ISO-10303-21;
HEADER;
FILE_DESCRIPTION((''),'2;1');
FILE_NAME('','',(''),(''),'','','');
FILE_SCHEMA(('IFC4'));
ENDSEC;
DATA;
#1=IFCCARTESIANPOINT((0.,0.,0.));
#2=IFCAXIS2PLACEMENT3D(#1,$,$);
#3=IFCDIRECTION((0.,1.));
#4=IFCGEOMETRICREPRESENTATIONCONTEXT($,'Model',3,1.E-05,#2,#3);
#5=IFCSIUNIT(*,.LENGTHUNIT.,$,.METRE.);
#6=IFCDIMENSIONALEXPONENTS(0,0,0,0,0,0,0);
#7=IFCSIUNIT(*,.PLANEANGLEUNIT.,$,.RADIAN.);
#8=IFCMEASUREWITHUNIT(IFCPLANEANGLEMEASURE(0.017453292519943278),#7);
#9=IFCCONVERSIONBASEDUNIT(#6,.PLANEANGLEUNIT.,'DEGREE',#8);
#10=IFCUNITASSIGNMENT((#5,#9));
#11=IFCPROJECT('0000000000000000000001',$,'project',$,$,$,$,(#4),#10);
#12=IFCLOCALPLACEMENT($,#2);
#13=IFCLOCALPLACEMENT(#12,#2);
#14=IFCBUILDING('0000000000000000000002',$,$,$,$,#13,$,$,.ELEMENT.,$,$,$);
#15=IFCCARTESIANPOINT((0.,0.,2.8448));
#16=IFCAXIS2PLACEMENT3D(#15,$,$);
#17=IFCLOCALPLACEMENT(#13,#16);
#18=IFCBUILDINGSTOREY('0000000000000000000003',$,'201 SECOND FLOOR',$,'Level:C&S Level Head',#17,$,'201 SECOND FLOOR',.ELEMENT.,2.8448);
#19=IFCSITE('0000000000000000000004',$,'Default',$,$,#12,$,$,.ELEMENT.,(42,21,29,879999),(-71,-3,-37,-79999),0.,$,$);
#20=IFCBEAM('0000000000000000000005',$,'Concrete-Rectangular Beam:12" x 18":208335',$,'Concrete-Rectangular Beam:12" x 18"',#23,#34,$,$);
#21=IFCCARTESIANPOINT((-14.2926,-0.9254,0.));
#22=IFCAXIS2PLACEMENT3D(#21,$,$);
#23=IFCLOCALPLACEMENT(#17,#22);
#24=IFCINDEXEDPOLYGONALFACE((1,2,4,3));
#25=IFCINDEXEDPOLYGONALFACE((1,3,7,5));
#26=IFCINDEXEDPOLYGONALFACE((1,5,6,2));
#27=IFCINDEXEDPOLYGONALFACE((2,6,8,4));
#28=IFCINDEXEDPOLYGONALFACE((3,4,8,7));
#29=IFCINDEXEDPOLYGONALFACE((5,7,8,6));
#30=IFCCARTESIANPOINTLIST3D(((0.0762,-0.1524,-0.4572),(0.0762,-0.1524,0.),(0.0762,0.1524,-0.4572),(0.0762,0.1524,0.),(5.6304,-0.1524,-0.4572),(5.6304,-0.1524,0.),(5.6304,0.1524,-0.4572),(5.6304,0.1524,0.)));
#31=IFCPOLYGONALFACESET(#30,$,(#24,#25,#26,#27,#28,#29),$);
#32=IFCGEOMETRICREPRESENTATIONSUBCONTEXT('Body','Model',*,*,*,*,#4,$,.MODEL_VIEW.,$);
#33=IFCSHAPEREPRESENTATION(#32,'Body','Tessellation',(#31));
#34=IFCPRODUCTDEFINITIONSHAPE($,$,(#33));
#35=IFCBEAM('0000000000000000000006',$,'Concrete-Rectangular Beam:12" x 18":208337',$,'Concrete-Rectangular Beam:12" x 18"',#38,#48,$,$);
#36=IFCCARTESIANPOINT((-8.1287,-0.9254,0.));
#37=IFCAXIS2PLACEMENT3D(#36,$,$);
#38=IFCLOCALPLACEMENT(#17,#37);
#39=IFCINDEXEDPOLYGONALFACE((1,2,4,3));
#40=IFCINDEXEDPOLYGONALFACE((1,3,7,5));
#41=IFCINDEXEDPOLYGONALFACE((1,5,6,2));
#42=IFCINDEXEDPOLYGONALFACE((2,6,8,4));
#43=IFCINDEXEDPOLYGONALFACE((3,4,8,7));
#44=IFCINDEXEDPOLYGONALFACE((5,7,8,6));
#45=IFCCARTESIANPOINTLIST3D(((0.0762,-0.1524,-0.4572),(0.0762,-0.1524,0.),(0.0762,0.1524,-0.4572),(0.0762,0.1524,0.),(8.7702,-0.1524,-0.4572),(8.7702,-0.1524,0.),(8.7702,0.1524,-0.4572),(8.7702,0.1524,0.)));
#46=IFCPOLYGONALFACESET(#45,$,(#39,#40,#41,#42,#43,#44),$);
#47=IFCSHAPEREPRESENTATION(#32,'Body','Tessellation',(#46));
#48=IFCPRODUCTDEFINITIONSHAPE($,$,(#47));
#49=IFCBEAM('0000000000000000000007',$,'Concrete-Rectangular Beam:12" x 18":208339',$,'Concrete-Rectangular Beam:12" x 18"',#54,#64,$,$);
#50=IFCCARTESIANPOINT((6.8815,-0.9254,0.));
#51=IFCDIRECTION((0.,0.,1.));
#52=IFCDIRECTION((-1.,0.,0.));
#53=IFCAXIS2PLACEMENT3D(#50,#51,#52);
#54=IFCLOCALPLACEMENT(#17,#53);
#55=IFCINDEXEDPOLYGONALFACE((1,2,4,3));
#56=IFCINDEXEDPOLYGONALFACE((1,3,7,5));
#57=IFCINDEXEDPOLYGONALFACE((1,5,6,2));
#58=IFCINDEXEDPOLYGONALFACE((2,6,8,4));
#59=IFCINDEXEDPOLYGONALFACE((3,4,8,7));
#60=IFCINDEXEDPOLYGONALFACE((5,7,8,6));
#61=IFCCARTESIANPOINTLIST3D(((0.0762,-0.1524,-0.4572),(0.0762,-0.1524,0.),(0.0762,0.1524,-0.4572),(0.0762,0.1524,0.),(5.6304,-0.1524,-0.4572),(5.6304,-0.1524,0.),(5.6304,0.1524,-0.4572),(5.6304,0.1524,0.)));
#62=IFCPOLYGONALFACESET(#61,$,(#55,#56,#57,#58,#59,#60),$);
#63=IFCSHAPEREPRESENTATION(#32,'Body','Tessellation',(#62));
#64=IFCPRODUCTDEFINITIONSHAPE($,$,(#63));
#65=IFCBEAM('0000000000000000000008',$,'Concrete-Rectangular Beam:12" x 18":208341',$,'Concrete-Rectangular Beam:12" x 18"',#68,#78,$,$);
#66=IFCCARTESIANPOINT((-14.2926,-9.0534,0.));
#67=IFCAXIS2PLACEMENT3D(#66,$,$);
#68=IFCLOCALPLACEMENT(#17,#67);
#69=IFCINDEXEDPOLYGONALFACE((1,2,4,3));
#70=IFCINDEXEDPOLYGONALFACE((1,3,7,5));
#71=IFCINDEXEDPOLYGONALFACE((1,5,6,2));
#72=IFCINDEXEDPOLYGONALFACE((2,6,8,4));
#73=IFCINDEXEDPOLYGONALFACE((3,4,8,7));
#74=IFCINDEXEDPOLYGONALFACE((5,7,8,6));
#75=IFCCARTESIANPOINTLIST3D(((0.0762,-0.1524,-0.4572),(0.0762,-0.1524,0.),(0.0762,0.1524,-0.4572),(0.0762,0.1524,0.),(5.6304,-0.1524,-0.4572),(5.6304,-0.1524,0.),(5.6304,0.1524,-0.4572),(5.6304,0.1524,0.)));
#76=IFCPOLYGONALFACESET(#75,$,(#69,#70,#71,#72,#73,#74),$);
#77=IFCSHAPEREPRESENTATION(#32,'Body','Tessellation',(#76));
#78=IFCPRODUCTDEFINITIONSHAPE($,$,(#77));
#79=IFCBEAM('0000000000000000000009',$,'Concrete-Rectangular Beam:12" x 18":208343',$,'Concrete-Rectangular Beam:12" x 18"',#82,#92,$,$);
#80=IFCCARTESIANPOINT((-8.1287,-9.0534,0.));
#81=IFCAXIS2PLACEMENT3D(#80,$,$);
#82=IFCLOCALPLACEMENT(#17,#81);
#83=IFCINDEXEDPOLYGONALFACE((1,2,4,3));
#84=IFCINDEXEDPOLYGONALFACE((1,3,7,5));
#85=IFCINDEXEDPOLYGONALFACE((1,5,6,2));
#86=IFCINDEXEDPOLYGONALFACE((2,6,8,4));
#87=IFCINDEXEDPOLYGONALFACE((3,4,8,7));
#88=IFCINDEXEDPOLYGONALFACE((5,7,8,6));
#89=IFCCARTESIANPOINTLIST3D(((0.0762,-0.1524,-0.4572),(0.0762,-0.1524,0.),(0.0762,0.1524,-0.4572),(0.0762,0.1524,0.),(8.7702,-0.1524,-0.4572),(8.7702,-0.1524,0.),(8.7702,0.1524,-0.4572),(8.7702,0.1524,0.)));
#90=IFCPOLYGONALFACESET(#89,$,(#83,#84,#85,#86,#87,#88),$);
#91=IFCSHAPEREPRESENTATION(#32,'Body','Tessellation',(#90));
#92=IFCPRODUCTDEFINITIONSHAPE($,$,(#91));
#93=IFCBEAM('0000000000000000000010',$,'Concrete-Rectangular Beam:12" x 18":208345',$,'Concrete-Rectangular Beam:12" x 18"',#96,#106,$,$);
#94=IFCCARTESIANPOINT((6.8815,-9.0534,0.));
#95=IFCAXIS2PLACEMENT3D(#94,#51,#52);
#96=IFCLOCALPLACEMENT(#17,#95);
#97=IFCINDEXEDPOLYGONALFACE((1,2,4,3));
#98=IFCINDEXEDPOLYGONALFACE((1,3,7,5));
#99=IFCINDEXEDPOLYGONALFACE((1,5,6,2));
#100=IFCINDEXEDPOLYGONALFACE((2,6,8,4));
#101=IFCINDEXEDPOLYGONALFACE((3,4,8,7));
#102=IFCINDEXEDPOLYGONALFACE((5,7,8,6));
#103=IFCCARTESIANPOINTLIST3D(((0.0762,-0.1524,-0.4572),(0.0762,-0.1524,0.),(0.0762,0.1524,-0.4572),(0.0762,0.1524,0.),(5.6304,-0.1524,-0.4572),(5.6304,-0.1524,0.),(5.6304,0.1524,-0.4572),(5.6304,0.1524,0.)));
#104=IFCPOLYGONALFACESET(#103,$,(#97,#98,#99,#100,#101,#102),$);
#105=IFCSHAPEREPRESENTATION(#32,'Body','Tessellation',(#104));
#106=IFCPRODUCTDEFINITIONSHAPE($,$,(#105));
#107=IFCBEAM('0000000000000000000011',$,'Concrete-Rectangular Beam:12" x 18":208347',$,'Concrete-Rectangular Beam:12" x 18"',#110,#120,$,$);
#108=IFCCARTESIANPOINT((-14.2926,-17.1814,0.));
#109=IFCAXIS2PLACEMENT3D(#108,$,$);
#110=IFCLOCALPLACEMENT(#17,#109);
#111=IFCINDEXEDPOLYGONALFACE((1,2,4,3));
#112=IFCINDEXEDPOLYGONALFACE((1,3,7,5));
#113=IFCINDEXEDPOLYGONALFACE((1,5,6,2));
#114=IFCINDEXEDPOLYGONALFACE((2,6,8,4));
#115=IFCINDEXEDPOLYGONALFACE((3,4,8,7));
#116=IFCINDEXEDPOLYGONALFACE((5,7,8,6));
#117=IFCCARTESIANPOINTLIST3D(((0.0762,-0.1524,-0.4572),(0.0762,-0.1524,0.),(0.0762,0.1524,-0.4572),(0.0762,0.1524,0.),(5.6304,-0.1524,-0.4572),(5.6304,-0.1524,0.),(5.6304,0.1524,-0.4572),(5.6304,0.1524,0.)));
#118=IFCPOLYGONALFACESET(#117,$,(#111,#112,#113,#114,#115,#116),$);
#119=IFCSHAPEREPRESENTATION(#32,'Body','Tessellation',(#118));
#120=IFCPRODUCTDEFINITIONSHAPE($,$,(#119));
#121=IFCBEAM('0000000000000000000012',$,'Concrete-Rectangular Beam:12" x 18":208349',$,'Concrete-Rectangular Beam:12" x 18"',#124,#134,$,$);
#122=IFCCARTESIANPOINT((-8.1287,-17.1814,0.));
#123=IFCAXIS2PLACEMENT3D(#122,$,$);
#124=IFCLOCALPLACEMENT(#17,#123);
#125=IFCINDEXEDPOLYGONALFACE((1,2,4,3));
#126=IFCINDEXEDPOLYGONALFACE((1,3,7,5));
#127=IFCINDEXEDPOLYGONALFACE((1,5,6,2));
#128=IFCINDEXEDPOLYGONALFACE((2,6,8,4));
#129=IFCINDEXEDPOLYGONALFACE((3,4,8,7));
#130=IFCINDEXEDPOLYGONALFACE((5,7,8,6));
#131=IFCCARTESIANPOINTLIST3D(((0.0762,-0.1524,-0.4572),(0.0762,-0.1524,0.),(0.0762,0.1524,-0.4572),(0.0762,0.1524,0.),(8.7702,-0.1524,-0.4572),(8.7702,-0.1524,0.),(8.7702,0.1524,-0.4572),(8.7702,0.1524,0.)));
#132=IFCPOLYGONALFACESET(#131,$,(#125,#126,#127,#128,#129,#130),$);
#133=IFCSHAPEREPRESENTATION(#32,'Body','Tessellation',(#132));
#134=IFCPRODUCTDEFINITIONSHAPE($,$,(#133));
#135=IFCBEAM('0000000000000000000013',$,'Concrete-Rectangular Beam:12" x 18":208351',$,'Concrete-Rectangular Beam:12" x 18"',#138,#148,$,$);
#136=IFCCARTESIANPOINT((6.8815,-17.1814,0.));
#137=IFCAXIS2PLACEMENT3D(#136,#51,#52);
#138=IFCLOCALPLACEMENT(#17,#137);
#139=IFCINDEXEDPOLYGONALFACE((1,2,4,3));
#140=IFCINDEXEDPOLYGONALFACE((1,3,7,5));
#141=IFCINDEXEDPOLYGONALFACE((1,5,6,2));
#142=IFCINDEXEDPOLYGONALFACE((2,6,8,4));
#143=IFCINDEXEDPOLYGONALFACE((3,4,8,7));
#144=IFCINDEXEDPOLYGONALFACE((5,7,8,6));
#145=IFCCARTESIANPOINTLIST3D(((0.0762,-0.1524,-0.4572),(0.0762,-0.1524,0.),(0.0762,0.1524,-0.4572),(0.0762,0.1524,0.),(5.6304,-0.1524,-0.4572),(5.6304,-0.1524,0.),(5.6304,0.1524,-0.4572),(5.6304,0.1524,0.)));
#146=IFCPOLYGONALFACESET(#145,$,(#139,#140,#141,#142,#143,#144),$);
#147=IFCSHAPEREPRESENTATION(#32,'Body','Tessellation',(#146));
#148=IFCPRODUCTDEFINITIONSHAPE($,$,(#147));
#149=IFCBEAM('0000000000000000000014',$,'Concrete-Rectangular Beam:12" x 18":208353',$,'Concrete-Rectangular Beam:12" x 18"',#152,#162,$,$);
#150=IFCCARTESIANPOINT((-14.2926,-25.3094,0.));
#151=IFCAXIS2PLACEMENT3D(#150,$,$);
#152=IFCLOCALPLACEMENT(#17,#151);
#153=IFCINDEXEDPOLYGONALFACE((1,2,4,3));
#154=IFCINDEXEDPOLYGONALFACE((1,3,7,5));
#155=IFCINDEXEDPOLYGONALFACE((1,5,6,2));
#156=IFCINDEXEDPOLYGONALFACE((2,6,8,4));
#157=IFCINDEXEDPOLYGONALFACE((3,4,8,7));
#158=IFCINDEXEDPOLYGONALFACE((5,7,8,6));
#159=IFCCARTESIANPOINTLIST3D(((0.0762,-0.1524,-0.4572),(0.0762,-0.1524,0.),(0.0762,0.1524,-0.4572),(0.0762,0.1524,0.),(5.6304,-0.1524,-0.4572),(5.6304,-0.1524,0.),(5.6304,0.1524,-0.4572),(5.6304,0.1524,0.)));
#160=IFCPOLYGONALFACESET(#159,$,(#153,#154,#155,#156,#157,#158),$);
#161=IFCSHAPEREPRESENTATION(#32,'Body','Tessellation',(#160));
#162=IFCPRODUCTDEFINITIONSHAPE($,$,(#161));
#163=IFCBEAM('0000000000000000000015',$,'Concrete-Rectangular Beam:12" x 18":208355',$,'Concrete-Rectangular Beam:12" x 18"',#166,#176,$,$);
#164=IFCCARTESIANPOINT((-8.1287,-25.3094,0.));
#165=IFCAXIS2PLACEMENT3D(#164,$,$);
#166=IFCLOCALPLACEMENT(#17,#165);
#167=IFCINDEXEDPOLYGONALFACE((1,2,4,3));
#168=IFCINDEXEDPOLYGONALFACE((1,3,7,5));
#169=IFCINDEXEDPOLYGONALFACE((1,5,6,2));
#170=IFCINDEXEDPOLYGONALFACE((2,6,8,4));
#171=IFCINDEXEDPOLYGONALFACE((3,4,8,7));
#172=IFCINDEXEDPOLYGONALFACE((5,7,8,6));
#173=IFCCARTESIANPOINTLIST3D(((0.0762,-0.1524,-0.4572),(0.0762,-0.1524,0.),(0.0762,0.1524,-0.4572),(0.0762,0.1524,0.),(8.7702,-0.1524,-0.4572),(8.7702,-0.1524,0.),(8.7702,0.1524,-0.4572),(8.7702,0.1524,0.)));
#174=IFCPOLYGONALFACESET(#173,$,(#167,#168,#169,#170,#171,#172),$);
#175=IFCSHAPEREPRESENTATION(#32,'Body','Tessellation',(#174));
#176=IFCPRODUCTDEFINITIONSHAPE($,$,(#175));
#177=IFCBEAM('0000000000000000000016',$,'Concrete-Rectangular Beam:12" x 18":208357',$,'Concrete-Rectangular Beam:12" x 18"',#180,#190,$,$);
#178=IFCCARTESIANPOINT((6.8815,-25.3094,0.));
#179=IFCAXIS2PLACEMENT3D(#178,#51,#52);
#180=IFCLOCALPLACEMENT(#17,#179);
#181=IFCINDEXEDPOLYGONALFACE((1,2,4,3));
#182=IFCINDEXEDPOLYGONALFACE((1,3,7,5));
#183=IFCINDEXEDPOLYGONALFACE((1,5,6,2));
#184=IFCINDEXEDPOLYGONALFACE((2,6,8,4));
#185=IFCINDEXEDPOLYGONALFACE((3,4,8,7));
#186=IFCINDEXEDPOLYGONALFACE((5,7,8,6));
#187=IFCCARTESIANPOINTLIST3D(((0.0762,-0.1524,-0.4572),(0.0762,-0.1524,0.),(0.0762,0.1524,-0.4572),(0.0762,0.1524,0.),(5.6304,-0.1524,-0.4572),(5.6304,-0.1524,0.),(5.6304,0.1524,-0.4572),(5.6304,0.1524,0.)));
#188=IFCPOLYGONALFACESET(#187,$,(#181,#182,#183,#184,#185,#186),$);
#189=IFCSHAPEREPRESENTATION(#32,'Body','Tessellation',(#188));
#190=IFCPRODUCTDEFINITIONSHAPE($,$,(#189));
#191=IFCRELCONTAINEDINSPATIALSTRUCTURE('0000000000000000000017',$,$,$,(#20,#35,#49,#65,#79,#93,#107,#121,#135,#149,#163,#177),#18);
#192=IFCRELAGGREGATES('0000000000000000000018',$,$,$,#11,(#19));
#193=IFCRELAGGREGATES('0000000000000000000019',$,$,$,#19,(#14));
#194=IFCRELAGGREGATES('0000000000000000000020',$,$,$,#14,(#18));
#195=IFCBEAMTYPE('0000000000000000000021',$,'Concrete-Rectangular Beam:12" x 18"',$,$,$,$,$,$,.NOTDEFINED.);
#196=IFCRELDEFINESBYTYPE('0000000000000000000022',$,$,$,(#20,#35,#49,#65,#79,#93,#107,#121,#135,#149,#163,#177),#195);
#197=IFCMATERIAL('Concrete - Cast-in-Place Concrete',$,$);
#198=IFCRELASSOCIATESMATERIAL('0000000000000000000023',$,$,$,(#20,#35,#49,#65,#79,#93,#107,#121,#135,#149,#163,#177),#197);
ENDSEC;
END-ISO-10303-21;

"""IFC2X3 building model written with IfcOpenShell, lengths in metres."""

from ifc_helpers import new_model, entity, si_unit, converted_unit, direction, frame, frame_2d, origin, origin_2d_with_axis, place, context, subcontext, project, spatial, rectangle, extrude, material, type_object, element, save


model = new_model("IFC2X3")

# Units and contexts
model_context = context("Model", 3, precision=1e-05, world=origin(), true_north=direction((0.0, 1.0)))
body_context = subcontext(model_context, "Body", "Model", "MODEL_VIEW")
ifc_project = project(units=[si_unit("LENGTHUNIT", "METRE"), converted_unit("PLANEANGLEUNIT", "DEGREE", entity("IfcPlaneAngleMeasure", 0.017453292519943278), si_unit("PLANEANGLEUNIT", "RADIAN"), dimensions=[0, 0, 0, 0, 0, 0, 0])], contexts=[model_context])

# Site, building, storey
site_placement = place(None, origin())
site = spatial("IfcSite", under=ifc_project, at=site_placement, Name="Default", CompositionType="ELEMENT", RefLatitude=(42, 21, 29, 879999), RefLongitude=(-71, -3, -37, -79999), RefElevation=0.0)
building_placement = place(site_placement, origin())
building = spatial("IfcBuilding", under=site, at=building_placement, CompositionType="ELEMENT")
storey_placement = place(building_placement, frame((0.0, 0.0, 2.8448)))
storey = spatial("IfcBuildingStorey", under=building, at=storey_placement, Name="201 SECOND FLOOR", ObjectType="Level:C&S Level Head", LongName="201 SECOND FLOOR", CompositionType="ELEMENT", Elevation=2.8448)

# Beams
ifc_material_1 = material(Name="Concrete - Cast-in-Place Concrete")
beam_type = type_object("IfcBeamType", Name="Concrete-Rectangular Beam:12\" x 18\"", PredefinedType="NOTDEFINED")
beam_1_placement = place(storey_placement, frame((-14.2926, -0.9254, 0.0)))
element("IfcBeam", 1, at=beam_1_placement, inside=storey, type_object=beam_type, material=ifc_material_1, Name="Concrete-Rectangular Beam:12\" x 18\":208335", ObjectType="Concrete-Rectangular Beam:12\" x 18\"", context=body_context, shape_type="SweptSolid", body=[
    extrude(rectangle(XDim=0.4572, YDim=0.3048, at=frame_2d((0.0, 0.0), x_axis=(1.0, 0.0))), frame((0.0762, 0.0, -0.2286), z_axis=(1.0, 0.0, 0.0), x_axis=(0.0, 0.0, -1.0)), (0.0, 0.0, 1.0), 5.5542),
])
beam_2_placement = place(storey_placement, frame((-8.1287, -0.9254, 0.0)))
element("IfcBeam", 2, at=beam_2_placement, inside=storey, type_object=beam_type, material=ifc_material_1, Name="Concrete-Rectangular Beam:12\" x 18\":208337", ObjectType="Concrete-Rectangular Beam:12\" x 18\"", context=body_context, shape_type="SweptSolid", body=[
    extrude(rectangle(XDim=0.4572, YDim=0.3048, at=frame_2d((0.0, 0.0), x_axis=(1.0, 0.0))), frame((0.0762, 0.0, -0.2286), z_axis=(1.0, 0.0, 0.0), x_axis=(0.0, 0.0, -1.0)), (0.0, 0.0, 1.0), 8.694),
])
beam_3_placement = place(storey_placement, frame((6.8815, -0.9254, 0.0), z_axis=(0.0, 0.0, 1.0), x_axis=(-1.0, 0.0, 0.0)))
element("IfcBeam", 3, at=beam_3_placement, inside=storey, type_object=beam_type, material=ifc_material_1, Name="Concrete-Rectangular Beam:12\" x 18\":208339", ObjectType="Concrete-Rectangular Beam:12\" x 18\"", context=body_context, shape_type="SweptSolid", body=[
    extrude(rectangle(XDim=0.4572, YDim=0.3048, at=frame_2d((0.0, 0.0), x_axis=(1.0, 0.0))), frame((0.0762, 0.0, -0.2286), z_axis=(1.0, 0.0, 0.0), x_axis=(0.0, 0.0, -1.0)), (0.0, 0.0, 1.0), 5.5542),
])
beam_4_placement = place(storey_placement, frame((-14.2926, -9.0534, 0.0)))
element("IfcBeam", 4, at=beam_4_placement, inside=storey, type_object=beam_type, material=ifc_material_1, Name="Concrete-Rectangular Beam:12\" x 18\":208341", ObjectType="Concrete-Rectangular Beam:12\" x 18\"", context=body_context, shape_type="SweptSolid", body=[
    extrude(rectangle(XDim=0.4572, YDim=0.3048, at=frame_2d((0.0, 0.0), x_axis=(1.0, 0.0))), frame((0.0762, 0.0, -0.2286), z_axis=(1.0, 0.0, 0.0), x_axis=(0.0, 0.0, -1.0)), (0.0, 0.0, 1.0), 5.5542),
])
beam_5_placement = place(storey_placement, frame((-8.1287, -9.0534, 0.0)))
element("IfcBeam", 5, at=beam_5_placement, inside=storey, type_object=beam_type, material=ifc_material_1, Name="Concrete-Rectangular Beam:12\" x 18\":208343", ObjectType="Concrete-Rectangular Beam:12\" x 18\"", context=body_context, shape_type="SweptSolid", body=[
    extrude(rectangle(XDim=0.4572, YDim=0.3048, at=frame_2d((0.0, 0.0), x_axis=(1.0, 0.0))), frame((0.0762, 0.0, -0.2286), z_axis=(1.0, 0.0, 0.0), x_axis=(0.0, 0.0, -1.0)), (0.0, 0.0, 1.0), 8.694),
])
beam_6_placement = place(storey_placement, frame((6.8815, -9.0534, 0.0), z_axis=(0.0, 0.0, 1.0), x_axis=(-1.0, 0.0, 0.0)))
element("IfcBeam", 6, at=beam_6_placement, inside=storey, type_object=beam_type, material=ifc_material_1, Name="Concrete-Rectangular Beam:12\" x 18\":208345", ObjectType="Concrete-Rectangular Beam:12\" x 18\"", context=body_context, shape_type="SweptSolid", body=[
    extrude(rectangle(XDim=0.4572, YDim=0.3048, at=frame_2d((0.0, 0.0), x_axis=(1.0, 0.0))), frame((0.0762, 0.0, -0.2286), z_axis=(1.0, 0.0, 0.0), x_axis=(0.0, 0.0, -1.0)), (0.0, 0.0, 1.0), 5.5542),
])
beam_7_placement = place(storey_placement, frame((-14.2926, -17.1814, 0.0)))
element("IfcBeam", 7, at=beam_7_placement, inside=storey, type_object=beam_type, material=ifc_material_1, Name="Concrete-Rectangular Beam:12\" x 18\":208347", ObjectType="Concrete-Rectangular Beam:12\" x 18\"", context=body_context, shape_type="SweptSolid", body=[
    extrude(rectangle(XDim=0.4572, YDim=0.3048, at=origin_2d_with_axis()), frame((0.0762, 0.0, -0.2286), z_axis=(1.0, 0.0, 0.0), x_axis=(0.0, 0.0, -1.0)), (0.0, 0.0, 1.0), 5.5542),
])
beam_8_placement = place(storey_placement, frame((-8.1287, -17.1814, 0.0)))
element("IfcBeam", 8, at=beam_8_placement, inside=storey, type_object=beam_type, material=ifc_material_1, Name="Concrete-Rectangular Beam:12\" x 18\":208349", ObjectType="Concrete-Rectangular Beam:12\" x 18\"", context=body_context, shape_type="SweptSolid", body=[
    extrude(rectangle(XDim=0.4572, YDim=0.3048, at=origin_2d_with_axis()), frame((0.0762, 0.0, -0.2286), z_axis=(1.0, 0.0, 0.0), x_axis=(0.0, 0.0, -1.0)), (0.0, 0.0, 1.0), 8.694),
])
beam_9_placement = place(storey_placement, frame((6.8815, -17.1814, 0.0), z_axis=(0.0, 0.0, 1.0), x_axis=(-1.0, 0.0, 0.0)))
element("IfcBeam", 9, at=beam_9_placement, inside=storey, type_object=beam_type, material=ifc_material_1, Name="Concrete-Rectangular Beam:12\" x 18\":208351", ObjectType="Concrete-Rectangular Beam:12\" x 18\"", context=body_context, shape_type="SweptSolid", body=[
    extrude(rectangle(XDim=0.4572, YDim=0.3048, at=origin_2d_with_axis()), frame((0.0762, 0.0, -0.2286), z_axis=(1.0, 0.0, 0.0), x_axis=(0.0, 0.0, -1.0)), (0.0, 0.0, 1.0), 5.5542),
])
beam_10_placement = place(storey_placement, frame((-14.2926, -25.3094, 0.0)))
element("IfcBeam", 10, at=beam_10_placement, inside=storey, type_object=beam_type, material=ifc_material_1, Name="Concrete-Rectangular Beam:12\" x 18\":208353", ObjectType="Concrete-Rectangular Beam:12\" x 18\"", context=body_context, shape_type="SweptSolid", body=[
    extrude(rectangle(XDim=0.4572, YDim=0.3048, at=frame_2d((0.0, 0.0), x_axis=(1.0, 0.0))), frame((0.0762, 0.0, -0.2286), z_axis=(1.0, 0.0, 0.0), x_axis=(0.0, 0.0, -1.0)), (0.0, 0.0, 1.0), 5.5542),
])
beam_11_placement = place(storey_placement, frame((-8.1287, -25.3094, 0.0)))
element("IfcBeam", 11, at=beam_11_placement, inside=storey, type_object=beam_type, material=ifc_material_1, Name="Concrete-Rectangular Beam:12\" x 18\":208355", ObjectType="Concrete-Rectangular Beam:12\" x 18\"", context=body_context, shape_type="SweptSolid", body=[
    extrude(rectangle(XDim=0.4572, YDim=0.3048, at=origin_2d_with_axis()), frame((0.0762, 0.0, -0.2286), z_axis=(1.0, 0.0, 0.0), x_axis=(0.0, 0.0, -1.0)), (0.0, 0.0, 1.0), 8.694),
])
beam_12_placement = place(storey_placement, frame((6.8815, -25.3094, 0.0), z_axis=(0.0, 0.0, 1.0), x_axis=(-1.0, 0.0, 0.0)))
element("IfcBeam", 12, at=beam_12_placement, inside=storey, type_object=beam_type, material=ifc_material_1, Name="Concrete-Rectangular Beam:12\" x 18\":208357", ObjectType="Concrete-Rectangular Beam:12\" x 18\"", context=body_context, shape_type="SweptSolid", body=[
    extrude(rectangle(XDim=0.4572, YDim=0.3048, at=frame_2d((0.0, 0.0), x_axis=(1.0, 0.0))), frame((0.0762, 0.0, -0.2286), z_axis=(1.0, 0.0, 0.0), x_axis=(0.0, 0.0, -1.0)), (0.0, 0.0, 1.0), 5.5542),
])

save(model, "model.ifc")
